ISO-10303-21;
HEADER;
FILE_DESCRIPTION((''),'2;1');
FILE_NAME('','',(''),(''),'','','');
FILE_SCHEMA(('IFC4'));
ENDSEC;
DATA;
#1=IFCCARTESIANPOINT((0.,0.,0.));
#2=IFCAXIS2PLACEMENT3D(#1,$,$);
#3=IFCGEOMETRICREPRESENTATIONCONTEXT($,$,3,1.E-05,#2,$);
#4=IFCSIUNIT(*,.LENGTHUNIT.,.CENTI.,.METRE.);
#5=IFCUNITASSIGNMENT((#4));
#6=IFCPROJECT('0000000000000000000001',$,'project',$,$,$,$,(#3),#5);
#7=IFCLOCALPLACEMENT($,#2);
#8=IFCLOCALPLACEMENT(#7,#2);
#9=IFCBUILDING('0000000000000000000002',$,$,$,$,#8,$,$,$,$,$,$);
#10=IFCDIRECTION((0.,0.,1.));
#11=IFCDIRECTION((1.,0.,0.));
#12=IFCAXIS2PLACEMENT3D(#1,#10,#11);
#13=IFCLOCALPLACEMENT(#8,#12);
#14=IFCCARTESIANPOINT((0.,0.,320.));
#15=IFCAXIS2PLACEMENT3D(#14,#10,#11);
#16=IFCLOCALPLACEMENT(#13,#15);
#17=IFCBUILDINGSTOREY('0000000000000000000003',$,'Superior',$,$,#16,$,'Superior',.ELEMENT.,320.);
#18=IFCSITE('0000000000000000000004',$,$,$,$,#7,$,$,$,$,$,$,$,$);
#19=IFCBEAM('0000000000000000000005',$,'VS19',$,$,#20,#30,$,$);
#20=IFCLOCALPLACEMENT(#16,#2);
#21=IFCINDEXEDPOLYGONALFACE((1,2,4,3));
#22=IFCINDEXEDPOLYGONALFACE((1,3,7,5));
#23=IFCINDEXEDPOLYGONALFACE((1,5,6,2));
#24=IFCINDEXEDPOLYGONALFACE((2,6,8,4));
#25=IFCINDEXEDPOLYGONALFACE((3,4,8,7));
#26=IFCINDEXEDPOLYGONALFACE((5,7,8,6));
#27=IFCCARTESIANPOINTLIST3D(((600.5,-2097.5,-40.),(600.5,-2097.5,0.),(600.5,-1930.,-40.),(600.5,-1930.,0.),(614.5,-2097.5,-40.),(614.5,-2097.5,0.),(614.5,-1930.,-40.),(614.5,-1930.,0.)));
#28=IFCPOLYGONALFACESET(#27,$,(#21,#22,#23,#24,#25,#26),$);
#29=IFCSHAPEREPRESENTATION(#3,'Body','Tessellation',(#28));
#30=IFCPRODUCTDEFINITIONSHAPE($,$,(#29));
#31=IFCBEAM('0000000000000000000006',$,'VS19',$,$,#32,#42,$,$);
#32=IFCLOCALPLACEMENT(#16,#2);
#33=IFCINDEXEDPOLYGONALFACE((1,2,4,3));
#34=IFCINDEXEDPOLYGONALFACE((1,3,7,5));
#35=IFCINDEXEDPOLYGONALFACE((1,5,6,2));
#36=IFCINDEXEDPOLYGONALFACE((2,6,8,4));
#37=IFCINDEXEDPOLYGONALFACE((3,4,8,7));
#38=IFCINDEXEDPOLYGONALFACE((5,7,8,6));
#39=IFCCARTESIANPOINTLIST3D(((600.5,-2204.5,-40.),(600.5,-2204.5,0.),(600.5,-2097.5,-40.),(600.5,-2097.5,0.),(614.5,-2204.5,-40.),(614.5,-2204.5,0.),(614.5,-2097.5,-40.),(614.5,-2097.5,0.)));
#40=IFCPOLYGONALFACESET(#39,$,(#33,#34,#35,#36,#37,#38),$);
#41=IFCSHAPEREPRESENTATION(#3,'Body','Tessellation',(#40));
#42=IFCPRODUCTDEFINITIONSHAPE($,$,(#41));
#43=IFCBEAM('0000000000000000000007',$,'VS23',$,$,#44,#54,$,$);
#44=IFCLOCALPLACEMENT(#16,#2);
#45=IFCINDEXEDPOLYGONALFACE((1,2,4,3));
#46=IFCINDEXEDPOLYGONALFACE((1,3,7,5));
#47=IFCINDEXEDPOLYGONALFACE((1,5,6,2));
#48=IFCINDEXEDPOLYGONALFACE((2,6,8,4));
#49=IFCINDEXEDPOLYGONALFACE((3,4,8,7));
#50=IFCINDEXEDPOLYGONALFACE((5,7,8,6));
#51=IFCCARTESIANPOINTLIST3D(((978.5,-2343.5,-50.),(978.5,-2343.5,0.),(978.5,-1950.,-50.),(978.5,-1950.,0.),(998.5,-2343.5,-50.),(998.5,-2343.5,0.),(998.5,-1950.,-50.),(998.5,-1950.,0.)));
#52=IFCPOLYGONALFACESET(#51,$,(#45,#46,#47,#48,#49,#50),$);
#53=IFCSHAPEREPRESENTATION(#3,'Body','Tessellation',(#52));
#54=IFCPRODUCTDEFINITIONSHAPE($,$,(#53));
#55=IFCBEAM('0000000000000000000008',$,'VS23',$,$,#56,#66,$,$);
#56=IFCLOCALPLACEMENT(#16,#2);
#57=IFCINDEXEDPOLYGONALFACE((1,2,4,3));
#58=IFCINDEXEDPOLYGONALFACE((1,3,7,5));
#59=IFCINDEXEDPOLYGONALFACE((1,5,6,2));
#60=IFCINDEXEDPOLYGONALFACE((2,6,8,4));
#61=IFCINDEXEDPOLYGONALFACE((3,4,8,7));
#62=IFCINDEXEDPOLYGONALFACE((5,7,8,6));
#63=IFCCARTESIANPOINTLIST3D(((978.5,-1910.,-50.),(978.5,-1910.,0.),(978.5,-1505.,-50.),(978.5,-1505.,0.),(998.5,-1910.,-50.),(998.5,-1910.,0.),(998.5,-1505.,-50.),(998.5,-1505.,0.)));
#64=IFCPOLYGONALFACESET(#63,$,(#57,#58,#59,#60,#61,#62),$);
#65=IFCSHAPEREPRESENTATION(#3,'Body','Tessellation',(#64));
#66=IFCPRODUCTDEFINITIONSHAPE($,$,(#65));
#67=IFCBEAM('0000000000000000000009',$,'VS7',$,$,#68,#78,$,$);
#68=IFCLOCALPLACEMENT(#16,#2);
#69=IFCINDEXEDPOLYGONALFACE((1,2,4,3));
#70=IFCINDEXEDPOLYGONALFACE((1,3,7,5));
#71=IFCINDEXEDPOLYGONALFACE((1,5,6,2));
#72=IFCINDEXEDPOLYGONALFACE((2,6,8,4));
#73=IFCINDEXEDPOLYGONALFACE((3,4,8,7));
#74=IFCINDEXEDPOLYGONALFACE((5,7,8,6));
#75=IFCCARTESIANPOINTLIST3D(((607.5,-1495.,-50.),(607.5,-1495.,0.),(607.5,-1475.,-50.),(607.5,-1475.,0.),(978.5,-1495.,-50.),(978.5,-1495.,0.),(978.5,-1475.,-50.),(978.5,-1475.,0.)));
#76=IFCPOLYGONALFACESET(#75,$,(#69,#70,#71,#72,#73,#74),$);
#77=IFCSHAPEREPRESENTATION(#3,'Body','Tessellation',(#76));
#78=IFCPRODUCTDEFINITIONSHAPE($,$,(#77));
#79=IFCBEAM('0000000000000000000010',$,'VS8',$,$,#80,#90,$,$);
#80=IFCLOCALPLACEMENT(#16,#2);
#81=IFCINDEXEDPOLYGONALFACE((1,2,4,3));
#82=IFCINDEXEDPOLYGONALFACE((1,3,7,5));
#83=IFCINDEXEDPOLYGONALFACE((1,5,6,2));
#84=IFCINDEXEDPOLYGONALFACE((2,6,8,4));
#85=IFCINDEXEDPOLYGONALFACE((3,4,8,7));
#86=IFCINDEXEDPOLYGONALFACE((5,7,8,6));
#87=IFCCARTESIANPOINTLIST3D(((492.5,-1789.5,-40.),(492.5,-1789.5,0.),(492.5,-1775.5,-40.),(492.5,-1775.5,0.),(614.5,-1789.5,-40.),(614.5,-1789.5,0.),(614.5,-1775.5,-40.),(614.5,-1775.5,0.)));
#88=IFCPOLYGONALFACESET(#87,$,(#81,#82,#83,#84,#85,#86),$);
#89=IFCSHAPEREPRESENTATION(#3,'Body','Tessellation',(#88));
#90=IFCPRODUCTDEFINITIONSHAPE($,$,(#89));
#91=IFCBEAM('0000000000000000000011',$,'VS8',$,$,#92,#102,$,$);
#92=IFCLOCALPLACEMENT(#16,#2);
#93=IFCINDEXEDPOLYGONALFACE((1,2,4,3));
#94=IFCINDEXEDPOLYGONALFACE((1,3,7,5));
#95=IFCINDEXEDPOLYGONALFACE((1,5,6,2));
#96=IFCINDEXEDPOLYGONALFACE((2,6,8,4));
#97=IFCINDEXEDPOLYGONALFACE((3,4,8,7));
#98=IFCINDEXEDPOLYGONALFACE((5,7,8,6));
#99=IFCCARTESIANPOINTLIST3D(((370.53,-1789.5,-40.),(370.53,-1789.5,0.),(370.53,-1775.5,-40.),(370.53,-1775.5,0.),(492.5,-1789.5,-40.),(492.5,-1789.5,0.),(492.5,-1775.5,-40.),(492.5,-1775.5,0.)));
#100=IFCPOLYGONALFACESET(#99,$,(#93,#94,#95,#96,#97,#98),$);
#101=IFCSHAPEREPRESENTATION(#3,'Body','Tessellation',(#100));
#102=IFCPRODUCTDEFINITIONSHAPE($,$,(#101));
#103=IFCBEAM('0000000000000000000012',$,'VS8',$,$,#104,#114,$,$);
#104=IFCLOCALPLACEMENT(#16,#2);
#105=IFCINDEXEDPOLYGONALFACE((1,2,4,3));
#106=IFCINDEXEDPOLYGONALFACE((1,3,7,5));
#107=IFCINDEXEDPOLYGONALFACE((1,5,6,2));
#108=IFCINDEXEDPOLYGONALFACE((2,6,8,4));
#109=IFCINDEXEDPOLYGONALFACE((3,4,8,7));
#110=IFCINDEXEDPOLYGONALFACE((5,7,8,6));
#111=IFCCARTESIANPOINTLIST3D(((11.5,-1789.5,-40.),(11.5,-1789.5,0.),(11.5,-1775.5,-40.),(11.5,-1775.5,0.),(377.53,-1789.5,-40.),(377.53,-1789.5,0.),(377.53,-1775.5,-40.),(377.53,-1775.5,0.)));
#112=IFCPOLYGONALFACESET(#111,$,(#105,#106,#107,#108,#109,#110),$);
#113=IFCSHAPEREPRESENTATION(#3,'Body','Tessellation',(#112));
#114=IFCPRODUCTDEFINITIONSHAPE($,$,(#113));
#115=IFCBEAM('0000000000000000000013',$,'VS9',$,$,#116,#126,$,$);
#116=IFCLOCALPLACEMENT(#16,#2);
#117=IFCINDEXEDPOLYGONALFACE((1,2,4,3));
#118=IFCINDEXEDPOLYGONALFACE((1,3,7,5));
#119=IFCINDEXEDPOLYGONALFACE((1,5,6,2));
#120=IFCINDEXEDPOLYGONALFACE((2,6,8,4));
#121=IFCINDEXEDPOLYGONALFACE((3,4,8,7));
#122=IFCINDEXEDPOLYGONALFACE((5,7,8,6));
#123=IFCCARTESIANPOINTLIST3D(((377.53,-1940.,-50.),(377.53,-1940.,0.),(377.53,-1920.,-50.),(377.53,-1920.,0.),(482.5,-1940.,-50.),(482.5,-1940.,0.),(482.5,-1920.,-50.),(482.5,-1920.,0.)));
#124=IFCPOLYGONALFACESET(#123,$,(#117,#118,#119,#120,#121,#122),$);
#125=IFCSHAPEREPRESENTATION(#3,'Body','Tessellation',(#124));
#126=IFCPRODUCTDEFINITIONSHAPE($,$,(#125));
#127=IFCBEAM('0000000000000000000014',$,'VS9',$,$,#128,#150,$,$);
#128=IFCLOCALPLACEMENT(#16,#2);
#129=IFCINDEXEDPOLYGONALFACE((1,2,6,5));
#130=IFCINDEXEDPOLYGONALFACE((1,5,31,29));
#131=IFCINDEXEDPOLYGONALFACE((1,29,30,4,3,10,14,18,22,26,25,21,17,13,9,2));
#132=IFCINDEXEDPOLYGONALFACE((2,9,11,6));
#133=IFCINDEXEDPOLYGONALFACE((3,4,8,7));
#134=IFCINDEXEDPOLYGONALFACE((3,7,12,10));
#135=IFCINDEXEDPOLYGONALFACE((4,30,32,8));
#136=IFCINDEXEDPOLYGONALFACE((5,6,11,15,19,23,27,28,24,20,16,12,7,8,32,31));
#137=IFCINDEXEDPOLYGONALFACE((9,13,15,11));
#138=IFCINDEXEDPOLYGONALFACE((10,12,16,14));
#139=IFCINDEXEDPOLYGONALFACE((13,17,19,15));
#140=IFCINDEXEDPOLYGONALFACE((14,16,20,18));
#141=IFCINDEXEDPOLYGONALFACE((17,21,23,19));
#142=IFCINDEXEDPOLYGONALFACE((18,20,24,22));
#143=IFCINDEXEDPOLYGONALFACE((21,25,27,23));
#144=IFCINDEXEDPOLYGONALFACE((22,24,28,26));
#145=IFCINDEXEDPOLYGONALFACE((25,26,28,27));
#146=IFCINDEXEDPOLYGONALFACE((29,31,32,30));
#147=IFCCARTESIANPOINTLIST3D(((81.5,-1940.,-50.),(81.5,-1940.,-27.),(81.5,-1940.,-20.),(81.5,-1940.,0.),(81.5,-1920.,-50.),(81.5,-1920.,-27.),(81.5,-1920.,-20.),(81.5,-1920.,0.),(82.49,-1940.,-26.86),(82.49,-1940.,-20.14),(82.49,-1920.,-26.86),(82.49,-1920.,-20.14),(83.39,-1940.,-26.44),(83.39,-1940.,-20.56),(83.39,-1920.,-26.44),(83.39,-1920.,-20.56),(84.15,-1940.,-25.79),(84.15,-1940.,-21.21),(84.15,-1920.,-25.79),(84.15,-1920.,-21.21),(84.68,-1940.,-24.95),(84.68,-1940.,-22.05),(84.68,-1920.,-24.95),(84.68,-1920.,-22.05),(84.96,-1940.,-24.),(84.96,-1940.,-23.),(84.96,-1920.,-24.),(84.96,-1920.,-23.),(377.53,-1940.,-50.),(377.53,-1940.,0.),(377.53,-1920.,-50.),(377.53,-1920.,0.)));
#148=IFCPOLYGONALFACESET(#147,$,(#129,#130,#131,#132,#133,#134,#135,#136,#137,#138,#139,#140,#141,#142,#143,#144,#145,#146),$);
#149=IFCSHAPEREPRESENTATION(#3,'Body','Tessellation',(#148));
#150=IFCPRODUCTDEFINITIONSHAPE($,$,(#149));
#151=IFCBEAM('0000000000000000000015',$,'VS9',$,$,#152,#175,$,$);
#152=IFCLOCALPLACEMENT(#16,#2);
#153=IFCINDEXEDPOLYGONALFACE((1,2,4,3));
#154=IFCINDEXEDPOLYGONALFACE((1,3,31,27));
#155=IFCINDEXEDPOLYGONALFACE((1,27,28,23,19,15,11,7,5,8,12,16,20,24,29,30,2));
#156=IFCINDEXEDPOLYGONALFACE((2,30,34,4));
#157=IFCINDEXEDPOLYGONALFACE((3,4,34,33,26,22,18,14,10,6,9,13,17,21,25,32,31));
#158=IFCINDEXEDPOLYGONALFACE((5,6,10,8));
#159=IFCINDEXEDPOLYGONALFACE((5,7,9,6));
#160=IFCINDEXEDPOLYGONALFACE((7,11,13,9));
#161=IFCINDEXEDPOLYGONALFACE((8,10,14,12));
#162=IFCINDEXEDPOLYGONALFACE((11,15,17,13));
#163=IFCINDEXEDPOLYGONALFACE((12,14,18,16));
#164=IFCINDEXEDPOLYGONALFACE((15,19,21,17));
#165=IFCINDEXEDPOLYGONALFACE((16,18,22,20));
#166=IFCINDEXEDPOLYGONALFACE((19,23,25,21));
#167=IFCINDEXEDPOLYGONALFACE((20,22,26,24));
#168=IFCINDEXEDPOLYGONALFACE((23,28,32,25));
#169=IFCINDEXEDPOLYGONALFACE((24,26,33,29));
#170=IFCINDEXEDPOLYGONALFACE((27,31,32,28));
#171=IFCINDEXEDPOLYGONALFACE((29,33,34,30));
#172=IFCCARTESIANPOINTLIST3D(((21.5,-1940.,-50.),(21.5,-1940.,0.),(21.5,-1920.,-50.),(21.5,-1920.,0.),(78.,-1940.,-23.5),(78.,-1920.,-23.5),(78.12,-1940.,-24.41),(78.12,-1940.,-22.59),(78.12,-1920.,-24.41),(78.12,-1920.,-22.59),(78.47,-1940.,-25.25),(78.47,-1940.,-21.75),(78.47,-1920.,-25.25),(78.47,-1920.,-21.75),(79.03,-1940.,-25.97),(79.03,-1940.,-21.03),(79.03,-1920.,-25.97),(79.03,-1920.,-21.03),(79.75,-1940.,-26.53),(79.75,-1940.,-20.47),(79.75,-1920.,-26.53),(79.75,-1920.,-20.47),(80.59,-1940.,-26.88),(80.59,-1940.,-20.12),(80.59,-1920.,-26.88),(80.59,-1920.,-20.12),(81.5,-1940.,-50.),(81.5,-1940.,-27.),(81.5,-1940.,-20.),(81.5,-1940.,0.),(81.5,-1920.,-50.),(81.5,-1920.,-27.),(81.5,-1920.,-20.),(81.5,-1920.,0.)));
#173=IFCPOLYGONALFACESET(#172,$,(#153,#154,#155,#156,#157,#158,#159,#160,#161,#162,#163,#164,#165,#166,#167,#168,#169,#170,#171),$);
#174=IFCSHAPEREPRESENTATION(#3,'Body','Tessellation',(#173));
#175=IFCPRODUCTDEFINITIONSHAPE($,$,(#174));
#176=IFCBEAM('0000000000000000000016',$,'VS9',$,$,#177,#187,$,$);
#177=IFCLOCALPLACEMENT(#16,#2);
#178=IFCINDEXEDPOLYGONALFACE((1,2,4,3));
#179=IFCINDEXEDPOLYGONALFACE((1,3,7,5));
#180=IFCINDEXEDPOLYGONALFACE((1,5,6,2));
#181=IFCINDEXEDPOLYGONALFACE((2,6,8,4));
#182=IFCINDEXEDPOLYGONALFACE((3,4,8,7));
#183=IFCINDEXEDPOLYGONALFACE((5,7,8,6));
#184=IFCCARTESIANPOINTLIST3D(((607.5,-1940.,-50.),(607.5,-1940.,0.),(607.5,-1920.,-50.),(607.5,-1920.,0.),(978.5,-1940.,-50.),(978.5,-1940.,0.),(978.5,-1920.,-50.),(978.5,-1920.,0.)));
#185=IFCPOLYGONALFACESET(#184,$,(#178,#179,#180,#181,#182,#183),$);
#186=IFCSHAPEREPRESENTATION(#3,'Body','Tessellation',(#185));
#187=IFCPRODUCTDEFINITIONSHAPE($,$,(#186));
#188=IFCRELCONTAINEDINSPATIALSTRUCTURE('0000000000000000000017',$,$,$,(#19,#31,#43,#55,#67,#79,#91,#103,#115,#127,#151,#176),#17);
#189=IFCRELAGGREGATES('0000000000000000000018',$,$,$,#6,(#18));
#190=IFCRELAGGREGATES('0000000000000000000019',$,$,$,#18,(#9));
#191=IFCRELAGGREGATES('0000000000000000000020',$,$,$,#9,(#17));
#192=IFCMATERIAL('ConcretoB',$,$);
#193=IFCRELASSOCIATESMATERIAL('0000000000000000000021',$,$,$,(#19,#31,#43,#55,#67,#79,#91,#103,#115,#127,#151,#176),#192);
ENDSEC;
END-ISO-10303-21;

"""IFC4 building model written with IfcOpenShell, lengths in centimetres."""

from ifc_helpers import new_model, si_unit, frame, origin, origin_with_axes, origin_2d_with_axis, place, context, project, spatial, polyline, circle, outline, extrude, material, element, save


model = new_model("IFC4")

# Units and contexts
context_of_model = context(None, 3, precision=1e-05, world=origin())
ifc_project = project(units=[si_unit("LENGTHUNIT", "METRE", prefix="CENTI")], contexts=[context_of_model])

# Site, building, storey
site_placement = place(None, origin())
site = spatial("IfcSite", under=ifc_project, at=site_placement)
building_placement = place(site_placement, origin())
building = spatial("IfcBuilding", under=site, at=building_placement)
placement = place(building_placement, origin_with_axes())
storey_placement = place(placement, frame((0.0, 0.0, 320.0), z_axis=(0.0, 0.0, 1.0), x_axis=(1.0, 0.0, 0.0)))
storey = spatial("IfcBuildingStorey", under=building, at=storey_placement, Name="Superior", LongName="Superior", CompositionType="ELEMENT", Elevation=320.0)

# Shared definitions
ifc_material = material(Name="ConcretoB")

# Beams
beam_1_placement = place(storey_placement, frame((607.5, -2013.75, 0.0), z_axis=(0.0, 0.0, 1.0), x_axis=(1.0, 0.0, 0.0)))
element("IfcBeam", 1, at=beam_1_placement, inside=storey, material=ifc_material, Name="VS19", context=context_of_model, shape_type="SolidModel", body=[
    extrude(outline(polyline([(-7.0, -20.0), (7.0, -20.0), (7.0, 20.0), (-7.0, 20.0), (-7.0, -20.0)])), frame((0.0, -83.75, -20.0), z_axis=(0.0, 1.0, 0.0), x_axis=(1.0, 0.0, 0.0)), (0.0, 0.0, 1.0), 167.5),
])
beam_2_placement = place(storey_placement, frame((607.5, -2151.0, 0.0), z_axis=(0.0, 0.0, 1.0), x_axis=(1.0, 0.0, 0.0)))
element("IfcBeam", 2, at=beam_2_placement, inside=storey, material=ifc_material, Name="VS19", context=context_of_model, shape_type="SolidModel", body=[
    extrude(outline(polyline([(-7.0, -20.0), (7.0, -20.0), (7.0, 20.0), (-7.0, 20.0), (-7.0, -20.0)])), frame((0.0, -53.5, -20.0), z_axis=(0.0, 1.0, 0.0), x_axis=(1.0, 0.0, 0.0)), (0.0, 0.0, 1.0), 107.0),
])
beam_3_placement = place(storey_placement, frame((988.5, -2146.75, 0.0), z_axis=(0.0, 0.0, 1.0), x_axis=(1.0, 0.0, 0.0)))
element("IfcBeam", 3, at=beam_3_placement, inside=storey, material=ifc_material, Name="VS23", context=context_of_model, shape_type="SolidModel", body=[
    extrude(outline(polyline([(-10.0, -25.0), (10.0, -25.0), (10.0, 25.0), (-10.0, 25.0), (-10.0, -25.0)])), frame((0.0, -196.75, -25.0), z_axis=(0.0, 1.0, 0.0), x_axis=(1.0, 0.0, 0.0)), (0.0, 0.0, 1.0), 393.5),
])
beam_4_placement = place(storey_placement, frame((988.5, -1707.5, 0.0), z_axis=(0.0, 0.0, 1.0), x_axis=(1.0, 0.0, 0.0)))
element("IfcBeam", 4, at=beam_4_placement, inside=storey, material=ifc_material, Name="VS23", context=context_of_model, shape_type="SolidModel", body=[
    extrude(outline(polyline([(-10.0, -25.0), (10.0, -25.0), (10.0, 25.0), (-10.0, 25.0), (-10.0, -25.0)])), frame((0.0, -202.5, -25.0), z_axis=(0.0, 1.0, 0.0), x_axis=(1.0, 0.0, 0.0)), (0.0, 0.0, 1.0), 405.0),
])
beam_5_placement = place(storey_placement, frame((793.0, -1485.0, 0.0), z_axis=(0.0, 0.0, 1.0), x_axis=(1.0, 0.0, 0.0)))
element("IfcBeam", 5, at=beam_5_placement, inside=storey, material=ifc_material, Name="VS7", context=context_of_model, shape_type="SolidModel", body=[
    extrude(outline(polyline([(-10.0, -25.0), (10.0, -25.0), (10.0, 25.0), (-10.0, 25.0), (-10.0, -25.0)])), frame((-185.5, 0.0, -25.0), z_axis=(1.0, 0.0, 0.0), x_axis=(0.0, -1.0, 0.0)), (0.0, 0.0, 1.0), 371.0),
])
beam_6_placement = place(storey_placement, frame((553.5, -1782.5, 0.0), z_axis=(0.0, 0.0, 1.0), x_axis=(1.0, 0.0, 0.0)))
element("IfcBeam", 6, at=beam_6_placement, inside=storey, material=ifc_material, Name="VS8", context=context_of_model, shape_type="SolidModel", body=[
    extrude(outline(polyline([(-7.0, -20.0), (7.0, -20.0), (7.0, 20.0), (-7.0, 20.0), (-7.0, -20.0)])), frame((-61.0, 0.0, -20.0), z_axis=(1.0, 0.0, 0.0), x_axis=(0.0, -1.0, 0.0)), (0.0, 0.0, 1.0), 122.0),
])
beam_7_placement = place(storey_placement, frame((431.51, -1782.5, 0.0), z_axis=(0.0, 0.0, 1.0), x_axis=(1.0, 0.0, 0.0)))
element("IfcBeam", 7, at=beam_7_placement, inside=storey, material=ifc_material, Name="VS8", context=context_of_model, shape_type="SolidModel", body=[
    extrude(outline(polyline([(-7.0, -20.0), (7.0, -20.0), (7.0, 20.0), (-7.0, 20.0), (-7.0, -20.0)])), frame((-60.98, 0.0, -20.0), z_axis=(1.0, 0.0, 0.0), x_axis=(0.0, -1.0, 0.0)), (0.0, 0.0, 1.0), 121.97),
])
beam_8_placement = place(storey_placement, frame((194.51, -1782.5, 0.0), z_axis=(0.0, 0.0, 1.0), x_axis=(1.0, 0.0, 0.0)))
element("IfcBeam", 8, at=beam_8_placement, inside=storey, material=ifc_material, Name="VS8", context=context_of_model, shape_type="SolidModel", body=[
    extrude(outline(polyline([(-7.0, -20.0), (7.0, -20.0), (7.0, 20.0), (-7.0, 20.0), (-7.0, -20.0)])), frame((-183.01, 0.0, -20.0), z_axis=(1.0, 0.0, 0.0), x_axis=(0.0, -1.0, 0.0)), (0.0, 0.0, 1.0), 366.03),
])
beam_9_placement = place(storey_placement, frame((430.01, -1930.0, 0.0), z_axis=(0.0, 0.0, 1.0), x_axis=(1.0, 0.0, 0.0)))
element("IfcBeam", 9, at=beam_9_placement, inside=storey, material=ifc_material, Name="VS9", context=context_of_model, shape_type="SolidModel", body=[
    extrude(outline(polyline([(-10.0, -25.0), (10.0, -25.0), (10.0, 25.0), (-10.0, 25.0), (-10.0, -25.0)])), frame((-52.48, 0.0, -25.0), z_axis=(1.0, 0.0, 0.0), x_axis=(0.0, -1.0, 0.0)), (0.0, 0.0, 1.0), 104.97),
])

# Beams, openings
beam_10_placement = place(storey_placement, frame((229.51, -1930.0, 0.0), z_axis=(0.0, 0.0, 1.0), x_axis=(1.0, 0.0, 0.0)))
beam_10 = element("IfcBeam", 10, at=beam_10_placement, inside=storey, material=ifc_material, Name="VS9", context=context_of_model, shape_type="SolidModel", body=[
    extrude(outline(polyline([(-10.0, -25.0), (10.0, -25.0), (10.0, 25.0), (-10.0, 25.0), (-10.0, -25.0)])), frame((-148.01, 0.0, -25.0), z_axis=(1.0, 0.0, 0.0), x_axis=(0.0, -1.0, 0.0)), (0.0, 0.0, 1.0), 296.03),
])
opening_1_placement = place(storey_placement, frame((0.0, 0.0, -320.0), z_axis=(0.0, 0.0, 1.0), x_axis=(1.0, 0.0, 0.0)))
element("IfcOpeningElement", 11, at=opening_1_placement, cuts=beam_10, material=ifc_material, context=context_of_model, shape_type="SweptSolid", body=[
    extrude(circle(Radius=3.5, at=origin_2d_with_axis()), frame((81.5, -1940.0, 296.5), z_axis=(0.0, 1.0, 0.0), x_axis=(-1.0, 0.0, 0.0)), (0.0, 0.0, 1.0), 20.0),
])
beam_11_placement = place(storey_placement, frame((51.5, -1930.0, 0.0), z_axis=(0.0, 0.0, 1.0), x_axis=(1.0, 0.0, 0.0)))
beam_11 = element("IfcBeam", 12, at=beam_11_placement, inside=storey, material=ifc_material, Name="VS9", context=context_of_model, shape_type="SolidModel", body=[
    extrude(outline(polyline([(-10.0, -25.0), (10.0, -25.0), (10.0, 25.0), (-10.0, 25.0), (-10.0, -25.0)])), frame((-30.0, 0.0, -25.0), z_axis=(1.0, 0.0, 0.0), x_axis=(0.0, -1.0, 0.0)), (0.0, 0.0, 1.0), 60.0),
])
opening_2_placement = place(storey_placement, frame((0.0, 0.0, -320.0), z_axis=(0.0, 0.0, 1.0), x_axis=(1.0, 0.0, 0.0)))
element("IfcOpeningElement", 13, at=opening_2_placement, cuts=beam_11, material=ifc_material, context=context_of_model, shape_type="SweptSolid", body=[
    extrude(circle(Radius=3.5, at=origin_2d_with_axis()), frame((81.5, -1940.0, 296.5), z_axis=(0.0, 1.0, 0.0), x_axis=(-1.0, 0.0, 0.0)), (0.0, 0.0, 1.0), 20.0),
])

# Beam
beam_12_placement = place(storey_placement, frame((793.0, -1930.0, 0.0), z_axis=(0.0, 0.0, 1.0), x_axis=(1.0, 0.0, 0.0)))
element("IfcBeam", 14, at=beam_12_placement, inside=storey, material=ifc_material, Name="VS9", context=context_of_model, shape_type="SolidModel", body=[
    extrude(outline(polyline([(-10.0, -25.0), (10.0, -25.0), (10.0, 25.0), (-10.0, 25.0), (-10.0, -25.0)])), frame((-185.5, 0.0, -25.0), z_axis=(1.0, 0.0, 0.0), x_axis=(0.0, -1.0, 0.0)), (0.0, 0.0, 1.0), 371.0),
])

save(model, "model.ifc")
